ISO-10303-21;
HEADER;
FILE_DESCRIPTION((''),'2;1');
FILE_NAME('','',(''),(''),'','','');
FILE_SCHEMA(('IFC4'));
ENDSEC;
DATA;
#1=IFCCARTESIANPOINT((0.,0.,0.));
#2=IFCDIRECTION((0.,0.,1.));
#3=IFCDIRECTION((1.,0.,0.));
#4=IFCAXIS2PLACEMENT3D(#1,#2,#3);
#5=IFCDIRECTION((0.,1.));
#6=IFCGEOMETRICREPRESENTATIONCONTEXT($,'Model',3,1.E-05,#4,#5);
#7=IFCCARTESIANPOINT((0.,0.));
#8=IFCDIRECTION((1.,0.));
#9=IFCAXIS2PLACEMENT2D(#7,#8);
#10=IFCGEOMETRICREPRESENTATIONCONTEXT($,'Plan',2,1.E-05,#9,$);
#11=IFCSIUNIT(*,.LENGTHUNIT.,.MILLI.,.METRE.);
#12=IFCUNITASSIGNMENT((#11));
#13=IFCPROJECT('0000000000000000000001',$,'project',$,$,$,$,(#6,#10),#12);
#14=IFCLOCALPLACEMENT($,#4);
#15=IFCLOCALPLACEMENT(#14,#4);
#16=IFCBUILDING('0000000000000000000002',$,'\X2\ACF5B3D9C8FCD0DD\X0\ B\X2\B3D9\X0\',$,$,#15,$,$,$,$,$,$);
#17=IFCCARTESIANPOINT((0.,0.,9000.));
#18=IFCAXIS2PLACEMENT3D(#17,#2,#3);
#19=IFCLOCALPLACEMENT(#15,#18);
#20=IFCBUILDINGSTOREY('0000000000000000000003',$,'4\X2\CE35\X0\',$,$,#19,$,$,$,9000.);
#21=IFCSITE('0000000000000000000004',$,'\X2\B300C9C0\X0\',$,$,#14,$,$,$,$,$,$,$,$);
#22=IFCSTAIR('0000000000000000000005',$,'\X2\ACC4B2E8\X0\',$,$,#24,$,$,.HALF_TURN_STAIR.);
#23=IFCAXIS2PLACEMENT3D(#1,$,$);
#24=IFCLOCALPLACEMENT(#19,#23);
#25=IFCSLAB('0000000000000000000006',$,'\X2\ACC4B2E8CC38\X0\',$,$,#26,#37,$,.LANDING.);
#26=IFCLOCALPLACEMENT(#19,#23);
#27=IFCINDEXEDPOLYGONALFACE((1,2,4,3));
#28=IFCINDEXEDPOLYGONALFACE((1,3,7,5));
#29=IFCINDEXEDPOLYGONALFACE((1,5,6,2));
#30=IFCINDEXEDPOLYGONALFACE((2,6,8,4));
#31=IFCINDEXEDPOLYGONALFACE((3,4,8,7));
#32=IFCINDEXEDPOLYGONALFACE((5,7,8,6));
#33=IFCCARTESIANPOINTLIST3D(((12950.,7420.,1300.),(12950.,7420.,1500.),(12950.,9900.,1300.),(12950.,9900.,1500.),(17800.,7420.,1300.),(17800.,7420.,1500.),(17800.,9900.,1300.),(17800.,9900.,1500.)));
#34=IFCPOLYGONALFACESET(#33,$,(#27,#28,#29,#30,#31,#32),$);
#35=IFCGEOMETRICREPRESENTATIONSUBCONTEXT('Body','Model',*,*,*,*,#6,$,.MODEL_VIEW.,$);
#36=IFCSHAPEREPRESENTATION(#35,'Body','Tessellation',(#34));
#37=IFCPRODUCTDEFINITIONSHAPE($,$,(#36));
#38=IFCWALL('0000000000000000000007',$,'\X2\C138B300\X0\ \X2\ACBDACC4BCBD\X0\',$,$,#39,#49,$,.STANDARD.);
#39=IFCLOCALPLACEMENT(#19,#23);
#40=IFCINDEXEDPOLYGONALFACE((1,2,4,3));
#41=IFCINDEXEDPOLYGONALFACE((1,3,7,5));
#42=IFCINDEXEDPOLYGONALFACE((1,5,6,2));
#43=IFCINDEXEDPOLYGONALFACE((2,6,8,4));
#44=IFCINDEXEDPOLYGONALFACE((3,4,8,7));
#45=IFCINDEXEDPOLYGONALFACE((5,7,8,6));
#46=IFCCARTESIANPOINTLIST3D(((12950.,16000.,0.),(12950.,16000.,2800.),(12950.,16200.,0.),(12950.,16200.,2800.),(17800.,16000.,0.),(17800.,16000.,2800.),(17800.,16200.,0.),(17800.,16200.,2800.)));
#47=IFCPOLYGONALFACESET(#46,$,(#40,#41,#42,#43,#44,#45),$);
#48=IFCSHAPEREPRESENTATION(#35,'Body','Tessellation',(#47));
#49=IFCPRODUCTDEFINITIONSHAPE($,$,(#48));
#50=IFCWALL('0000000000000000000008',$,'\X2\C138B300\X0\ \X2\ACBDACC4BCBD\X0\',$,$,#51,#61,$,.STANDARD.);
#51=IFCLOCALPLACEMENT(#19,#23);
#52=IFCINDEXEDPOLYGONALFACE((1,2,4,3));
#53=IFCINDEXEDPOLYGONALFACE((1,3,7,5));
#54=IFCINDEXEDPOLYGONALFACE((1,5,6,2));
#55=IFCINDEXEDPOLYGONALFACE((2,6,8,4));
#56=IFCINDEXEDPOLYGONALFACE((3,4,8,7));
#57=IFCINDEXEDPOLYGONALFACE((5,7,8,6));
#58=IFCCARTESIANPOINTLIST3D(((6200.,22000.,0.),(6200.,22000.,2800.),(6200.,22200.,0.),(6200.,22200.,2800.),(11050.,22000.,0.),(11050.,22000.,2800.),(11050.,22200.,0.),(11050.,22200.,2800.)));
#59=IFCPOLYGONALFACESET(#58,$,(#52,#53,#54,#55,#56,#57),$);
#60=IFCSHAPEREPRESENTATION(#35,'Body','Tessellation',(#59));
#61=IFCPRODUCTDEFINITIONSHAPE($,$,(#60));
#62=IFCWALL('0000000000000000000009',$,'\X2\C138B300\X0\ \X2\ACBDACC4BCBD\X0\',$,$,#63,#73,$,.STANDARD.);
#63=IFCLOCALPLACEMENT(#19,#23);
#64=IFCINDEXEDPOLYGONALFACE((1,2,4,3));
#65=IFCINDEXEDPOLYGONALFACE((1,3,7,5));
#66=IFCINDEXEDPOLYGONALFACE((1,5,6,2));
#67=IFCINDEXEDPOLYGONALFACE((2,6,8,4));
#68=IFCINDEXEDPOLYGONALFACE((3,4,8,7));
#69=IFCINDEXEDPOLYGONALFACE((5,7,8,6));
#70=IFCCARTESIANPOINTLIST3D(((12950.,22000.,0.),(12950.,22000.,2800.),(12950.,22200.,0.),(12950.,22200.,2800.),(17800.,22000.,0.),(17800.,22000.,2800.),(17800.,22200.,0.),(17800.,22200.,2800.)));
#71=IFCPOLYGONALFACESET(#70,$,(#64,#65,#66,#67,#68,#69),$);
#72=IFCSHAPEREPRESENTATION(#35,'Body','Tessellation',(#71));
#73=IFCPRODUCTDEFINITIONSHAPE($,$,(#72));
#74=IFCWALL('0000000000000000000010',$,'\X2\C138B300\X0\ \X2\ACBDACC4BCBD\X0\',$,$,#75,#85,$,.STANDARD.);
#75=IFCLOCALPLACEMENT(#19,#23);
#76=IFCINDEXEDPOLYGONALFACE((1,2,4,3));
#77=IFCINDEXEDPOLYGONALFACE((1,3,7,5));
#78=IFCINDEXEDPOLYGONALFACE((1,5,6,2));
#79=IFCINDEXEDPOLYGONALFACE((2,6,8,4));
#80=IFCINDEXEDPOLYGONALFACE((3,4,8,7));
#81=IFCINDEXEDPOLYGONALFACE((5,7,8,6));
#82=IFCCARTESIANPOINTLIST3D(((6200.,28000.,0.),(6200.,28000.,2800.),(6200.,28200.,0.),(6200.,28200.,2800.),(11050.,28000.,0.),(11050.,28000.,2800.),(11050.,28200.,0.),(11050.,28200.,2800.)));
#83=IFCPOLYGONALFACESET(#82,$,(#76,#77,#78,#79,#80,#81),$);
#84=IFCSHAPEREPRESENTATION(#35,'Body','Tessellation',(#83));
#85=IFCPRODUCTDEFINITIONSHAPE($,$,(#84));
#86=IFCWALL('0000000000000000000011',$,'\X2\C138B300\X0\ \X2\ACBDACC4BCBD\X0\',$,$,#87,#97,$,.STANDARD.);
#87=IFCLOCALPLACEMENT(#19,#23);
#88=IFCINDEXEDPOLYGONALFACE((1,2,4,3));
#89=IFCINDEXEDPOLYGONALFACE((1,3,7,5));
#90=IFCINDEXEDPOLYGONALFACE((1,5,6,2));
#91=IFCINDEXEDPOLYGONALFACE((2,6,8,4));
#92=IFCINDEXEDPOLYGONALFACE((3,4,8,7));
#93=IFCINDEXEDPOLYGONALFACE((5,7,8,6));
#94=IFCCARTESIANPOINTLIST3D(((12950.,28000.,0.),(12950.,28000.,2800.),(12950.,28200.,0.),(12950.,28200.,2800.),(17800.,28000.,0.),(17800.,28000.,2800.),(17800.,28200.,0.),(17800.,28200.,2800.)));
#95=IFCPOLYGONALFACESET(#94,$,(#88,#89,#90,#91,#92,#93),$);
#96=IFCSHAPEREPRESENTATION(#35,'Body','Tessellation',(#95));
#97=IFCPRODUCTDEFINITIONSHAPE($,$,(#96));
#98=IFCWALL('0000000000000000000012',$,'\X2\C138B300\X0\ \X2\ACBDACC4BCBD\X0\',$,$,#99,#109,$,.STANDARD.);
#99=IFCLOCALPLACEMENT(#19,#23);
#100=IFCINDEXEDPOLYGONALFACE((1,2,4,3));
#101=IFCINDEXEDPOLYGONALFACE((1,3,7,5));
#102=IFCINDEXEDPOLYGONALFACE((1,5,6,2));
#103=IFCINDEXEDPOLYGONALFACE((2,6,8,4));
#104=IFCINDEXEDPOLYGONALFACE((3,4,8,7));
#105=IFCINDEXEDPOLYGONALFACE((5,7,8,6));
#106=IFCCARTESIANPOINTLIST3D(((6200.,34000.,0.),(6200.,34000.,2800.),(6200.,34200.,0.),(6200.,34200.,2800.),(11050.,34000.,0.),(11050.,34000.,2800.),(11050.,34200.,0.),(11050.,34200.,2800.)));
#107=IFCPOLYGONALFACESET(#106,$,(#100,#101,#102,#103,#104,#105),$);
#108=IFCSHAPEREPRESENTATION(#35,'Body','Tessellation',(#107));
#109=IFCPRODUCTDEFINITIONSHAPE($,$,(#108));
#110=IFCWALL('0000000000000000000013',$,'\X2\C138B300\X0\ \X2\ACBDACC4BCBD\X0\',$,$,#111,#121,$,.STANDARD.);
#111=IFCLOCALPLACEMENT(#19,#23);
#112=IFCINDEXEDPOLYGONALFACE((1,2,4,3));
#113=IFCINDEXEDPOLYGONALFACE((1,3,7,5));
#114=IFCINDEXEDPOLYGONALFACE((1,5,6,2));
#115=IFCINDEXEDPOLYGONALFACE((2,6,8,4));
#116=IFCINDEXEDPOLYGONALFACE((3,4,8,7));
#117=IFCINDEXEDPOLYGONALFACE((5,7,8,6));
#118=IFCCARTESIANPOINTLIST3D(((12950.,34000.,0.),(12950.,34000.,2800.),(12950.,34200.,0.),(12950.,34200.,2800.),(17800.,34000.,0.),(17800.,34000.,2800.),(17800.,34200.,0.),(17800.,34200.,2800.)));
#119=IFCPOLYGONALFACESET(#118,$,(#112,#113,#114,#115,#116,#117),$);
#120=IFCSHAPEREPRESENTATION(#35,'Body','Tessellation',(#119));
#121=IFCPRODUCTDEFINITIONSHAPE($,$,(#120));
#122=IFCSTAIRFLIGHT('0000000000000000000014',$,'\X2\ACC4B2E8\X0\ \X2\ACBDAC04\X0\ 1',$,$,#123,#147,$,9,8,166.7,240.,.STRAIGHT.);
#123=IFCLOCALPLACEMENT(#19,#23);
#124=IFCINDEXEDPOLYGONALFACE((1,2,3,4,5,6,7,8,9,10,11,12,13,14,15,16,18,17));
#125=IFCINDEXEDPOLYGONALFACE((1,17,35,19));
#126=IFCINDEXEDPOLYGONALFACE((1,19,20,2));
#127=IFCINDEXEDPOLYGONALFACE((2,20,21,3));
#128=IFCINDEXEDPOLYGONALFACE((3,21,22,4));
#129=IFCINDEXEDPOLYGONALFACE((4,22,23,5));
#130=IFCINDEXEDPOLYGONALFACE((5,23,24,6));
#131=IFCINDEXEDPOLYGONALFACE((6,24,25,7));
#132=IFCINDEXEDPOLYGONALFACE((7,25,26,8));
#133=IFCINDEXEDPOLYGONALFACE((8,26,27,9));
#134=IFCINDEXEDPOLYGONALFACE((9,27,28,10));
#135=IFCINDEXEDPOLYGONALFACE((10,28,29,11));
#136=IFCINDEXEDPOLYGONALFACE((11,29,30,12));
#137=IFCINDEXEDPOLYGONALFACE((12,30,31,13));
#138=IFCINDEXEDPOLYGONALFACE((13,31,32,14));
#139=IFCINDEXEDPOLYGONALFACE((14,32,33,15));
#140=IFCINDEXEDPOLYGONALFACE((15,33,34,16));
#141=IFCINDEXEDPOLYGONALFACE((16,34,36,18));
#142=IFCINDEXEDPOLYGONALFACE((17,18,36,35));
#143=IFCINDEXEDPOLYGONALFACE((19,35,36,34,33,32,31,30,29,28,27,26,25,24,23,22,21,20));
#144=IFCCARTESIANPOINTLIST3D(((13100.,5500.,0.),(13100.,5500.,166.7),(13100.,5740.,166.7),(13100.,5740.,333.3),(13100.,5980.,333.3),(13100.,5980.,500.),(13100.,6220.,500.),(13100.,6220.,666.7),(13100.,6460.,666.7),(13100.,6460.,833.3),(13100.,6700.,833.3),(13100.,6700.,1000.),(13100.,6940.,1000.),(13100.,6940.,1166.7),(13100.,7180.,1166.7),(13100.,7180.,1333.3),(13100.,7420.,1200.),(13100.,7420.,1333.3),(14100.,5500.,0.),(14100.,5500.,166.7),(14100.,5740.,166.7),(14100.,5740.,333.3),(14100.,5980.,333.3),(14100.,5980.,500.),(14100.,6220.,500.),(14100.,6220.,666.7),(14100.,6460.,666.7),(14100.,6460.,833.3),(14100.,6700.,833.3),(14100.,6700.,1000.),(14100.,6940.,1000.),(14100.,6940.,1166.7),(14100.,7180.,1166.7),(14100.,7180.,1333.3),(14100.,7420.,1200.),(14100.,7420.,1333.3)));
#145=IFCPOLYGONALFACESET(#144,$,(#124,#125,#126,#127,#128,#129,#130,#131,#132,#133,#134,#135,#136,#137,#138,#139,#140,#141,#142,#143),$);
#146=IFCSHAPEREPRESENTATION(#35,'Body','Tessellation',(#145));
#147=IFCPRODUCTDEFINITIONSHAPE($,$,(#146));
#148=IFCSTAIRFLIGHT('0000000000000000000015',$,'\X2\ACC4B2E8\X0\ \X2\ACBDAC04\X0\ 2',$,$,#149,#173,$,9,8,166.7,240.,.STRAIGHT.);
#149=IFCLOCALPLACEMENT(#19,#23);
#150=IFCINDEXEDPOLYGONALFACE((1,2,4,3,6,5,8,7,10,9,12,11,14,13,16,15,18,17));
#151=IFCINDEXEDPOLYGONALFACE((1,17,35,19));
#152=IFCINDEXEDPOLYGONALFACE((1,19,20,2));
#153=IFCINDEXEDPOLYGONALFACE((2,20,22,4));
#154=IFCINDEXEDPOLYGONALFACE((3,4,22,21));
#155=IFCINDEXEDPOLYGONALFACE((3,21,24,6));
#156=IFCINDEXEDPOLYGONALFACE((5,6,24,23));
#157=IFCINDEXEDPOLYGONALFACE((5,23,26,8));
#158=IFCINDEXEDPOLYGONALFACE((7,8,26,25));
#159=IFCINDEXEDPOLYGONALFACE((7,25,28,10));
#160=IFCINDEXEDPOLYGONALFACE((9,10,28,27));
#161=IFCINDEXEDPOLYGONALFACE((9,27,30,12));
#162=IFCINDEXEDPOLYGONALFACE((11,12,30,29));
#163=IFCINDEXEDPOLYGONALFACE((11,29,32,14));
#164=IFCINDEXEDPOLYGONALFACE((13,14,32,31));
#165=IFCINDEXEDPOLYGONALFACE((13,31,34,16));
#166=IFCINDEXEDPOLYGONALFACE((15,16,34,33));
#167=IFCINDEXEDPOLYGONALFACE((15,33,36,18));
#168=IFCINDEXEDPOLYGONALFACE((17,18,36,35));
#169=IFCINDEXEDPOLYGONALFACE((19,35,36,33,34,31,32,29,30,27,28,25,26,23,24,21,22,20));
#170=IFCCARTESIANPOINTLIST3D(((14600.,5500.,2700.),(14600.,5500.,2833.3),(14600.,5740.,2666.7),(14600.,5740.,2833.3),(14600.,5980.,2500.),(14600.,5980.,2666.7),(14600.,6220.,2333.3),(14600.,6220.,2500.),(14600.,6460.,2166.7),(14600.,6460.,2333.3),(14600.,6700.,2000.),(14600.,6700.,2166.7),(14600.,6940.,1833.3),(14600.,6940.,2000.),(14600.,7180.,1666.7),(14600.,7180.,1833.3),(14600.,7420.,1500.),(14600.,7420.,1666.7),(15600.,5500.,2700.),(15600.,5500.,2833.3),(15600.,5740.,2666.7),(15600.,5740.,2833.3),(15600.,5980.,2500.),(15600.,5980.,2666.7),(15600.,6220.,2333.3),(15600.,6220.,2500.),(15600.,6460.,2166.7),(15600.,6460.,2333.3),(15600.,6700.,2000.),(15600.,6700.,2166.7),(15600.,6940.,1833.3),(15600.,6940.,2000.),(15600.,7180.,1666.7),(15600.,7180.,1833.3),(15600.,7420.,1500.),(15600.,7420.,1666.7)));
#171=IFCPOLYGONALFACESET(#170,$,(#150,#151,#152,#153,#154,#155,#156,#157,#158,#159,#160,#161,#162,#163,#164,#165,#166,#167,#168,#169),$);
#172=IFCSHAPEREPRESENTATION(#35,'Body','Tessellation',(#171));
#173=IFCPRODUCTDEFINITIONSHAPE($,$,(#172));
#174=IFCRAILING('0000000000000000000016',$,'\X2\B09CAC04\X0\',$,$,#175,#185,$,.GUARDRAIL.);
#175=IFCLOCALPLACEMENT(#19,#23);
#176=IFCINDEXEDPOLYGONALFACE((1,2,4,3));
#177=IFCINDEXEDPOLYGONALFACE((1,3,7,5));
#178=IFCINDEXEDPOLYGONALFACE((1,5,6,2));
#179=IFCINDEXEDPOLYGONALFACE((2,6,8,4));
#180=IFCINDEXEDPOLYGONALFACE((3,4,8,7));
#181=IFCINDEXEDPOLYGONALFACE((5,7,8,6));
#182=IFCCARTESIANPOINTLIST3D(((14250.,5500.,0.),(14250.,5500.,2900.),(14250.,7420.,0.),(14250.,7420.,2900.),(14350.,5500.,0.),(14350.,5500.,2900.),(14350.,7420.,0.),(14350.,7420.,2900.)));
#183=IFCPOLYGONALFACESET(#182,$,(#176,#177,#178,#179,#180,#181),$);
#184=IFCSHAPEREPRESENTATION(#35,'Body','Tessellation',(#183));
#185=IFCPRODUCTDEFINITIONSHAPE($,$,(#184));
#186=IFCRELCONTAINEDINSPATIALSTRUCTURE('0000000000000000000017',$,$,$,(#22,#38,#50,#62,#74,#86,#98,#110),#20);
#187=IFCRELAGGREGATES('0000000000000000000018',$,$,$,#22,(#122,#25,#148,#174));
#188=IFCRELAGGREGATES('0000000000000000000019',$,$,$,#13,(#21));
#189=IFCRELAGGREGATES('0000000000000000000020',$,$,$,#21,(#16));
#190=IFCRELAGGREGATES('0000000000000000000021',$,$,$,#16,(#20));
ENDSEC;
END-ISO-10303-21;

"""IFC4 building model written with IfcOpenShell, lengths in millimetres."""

from ifc_helpers import new_model, si_unit, direction, frame, origin_with_axes, origin_2d_with_axis, place, context, subcontext, project, spatial, polyline, outline, extrude, element, aggregate, save


model = new_model("IFC4")

# Units and contexts
model_context = context("Model", 3, precision=1e-05, world=origin_with_axes(), true_north=direction((0.0, 1.0)))
plan_context = context("Plan", 2, precision=1e-05, world=origin_2d_with_axis())
body_context = subcontext(model_context, "Body", "Model", "MODEL_VIEW")
ifc_project = project(units=[si_unit("LENGTHUNIT", "METRE", prefix="MILLI")], contexts=[model_context, plan_context])

# Site, building, storey
site_placement = place(None, origin_with_axes())
site = spatial("IfcSite", under=ifc_project, at=site_placement, Name="대지")
building_placement = place(site_placement, origin_with_axes())
building = spatial("IfcBuilding", under=site, at=building_placement, Name="공동주택 B동")
storey_placement = place(building_placement, frame((0.0, 0.0, 9000.0), z_axis=(0.0, 0.0, 1.0), x_axis=(1.0, 0.0, 0.0)))
storey = spatial("IfcBuildingStorey", under=building, at=storey_placement, Name="4층", Elevation=9000.0)

# Stair, slab
stair_placement = place(storey_placement, origin_with_axes())
stair = element("IfcStair", 1, at=stair_placement, inside=storey, Name="계단", PredefinedType="HALF_TURN_STAIR")
slab_placement = place(stair_placement, origin_with_axes())
slab = element("IfcSlab", 2, at=slab_placement, Name="계단참", PredefinedType="LANDING", context=body_context, shape_type="SweptSolid", body=[
    extrude(outline(polyline([(12950.0, 7420.0), (17800.0, 7420.0), (17800.0, 9900.0), (12950.0, 9900.0), (12950.0, 7420.0)])), frame((0.0, 0.0, 1300.0), z_axis=(0.0, 0.0, 1.0), x_axis=(1.0, 0.0, 0.0)), (0.0, 0.0, 1.0), 200.0),
])

# Walls
wall_1_placement = place(storey_placement, origin_with_axes())
element("IfcWall", 3, at=wall_1_placement, inside=storey, Name="세대 경계벽", PredefinedType="STANDARD", context=body_context, shape_type="SweptSolid", body=[
    extrude(outline(polyline([(12950.0, 16200.0), (17800.0, 16200.0), (17800.0, 16000.0), (12950.0, 16000.0), (12950.0, 16200.0)])), origin_with_axes(), (0.0, 0.0, 1.0), 2800.0),
])
wall_2_placement = place(storey_placement, origin_with_axes())
element("IfcWall", 4, at=wall_2_placement, inside=storey, Name="세대 경계벽", PredefinedType="STANDARD", context=body_context, shape_type="SweptSolid", body=[
    extrude(outline(polyline([(6200.0, 22200.0), (11050.0, 22200.0), (11050.0, 22000.0), (6200.0, 22000.0), (6200.0, 22200.0)])), origin_with_axes(), (0.0, 0.0, 1.0), 2800.0),
])
wall_3_placement = place(storey_placement, origin_with_axes())
element("IfcWall", 5, at=wall_3_placement, inside=storey, Name="세대 경계벽", PredefinedType="STANDARD", context=body_context, shape_type="SweptSolid", body=[
    extrude(outline(polyline([(12950.0, 22200.0), (17800.0, 22200.0), (17800.0, 22000.0), (12950.0, 22000.0), (12950.0, 22200.0)])), origin_with_axes(), (0.0, 0.0, 1.0), 2800.0),
])
wall_4_placement = place(storey_placement, origin_with_axes())
element("IfcWall", 6, at=wall_4_placement, inside=storey, Name="세대 경계벽", PredefinedType="STANDARD", context=body_context, shape_type="SweptSolid", body=[
    extrude(outline(polyline([(6200.0, 28200.0), (11050.0, 28200.0), (11050.0, 28000.0), (6200.0, 28000.0), (6200.0, 28200.0)])), origin_with_axes(), (0.0, 0.0, 1.0), 2800.0),
])
wall_5_placement = place(storey_placement, origin_with_axes())
element("IfcWall", 7, at=wall_5_placement, inside=storey, Name="세대 경계벽", PredefinedType="STANDARD", context=body_context, shape_type="SweptSolid", body=[
    extrude(outline(polyline([(12950.0, 28200.0), (17800.0, 28200.0), (17800.0, 28000.0), (12950.0, 28000.0), (12950.0, 28200.0)])), origin_with_axes(), (0.0, 0.0, 1.0), 2800.0),
])
wall_6_placement = place(storey_placement, origin_with_axes())
element("IfcWall", 8, at=wall_6_placement, inside=storey, Name="세대 경계벽", PredefinedType="STANDARD", context=body_context, shape_type="SweptSolid", body=[
    extrude(outline(polyline([(6200.0, 34200.0), (11050.0, 34200.0), (11050.0, 34000.0), (6200.0, 34000.0), (6200.0, 34200.0)])), origin_with_axes(), (0.0, 0.0, 1.0), 2800.0),
])
wall_7_placement = place(storey_placement, origin_with_axes())
element("IfcWall", 9, at=wall_7_placement, inside=storey, Name="세대 경계벽", PredefinedType="STANDARD", context=body_context, shape_type="SweptSolid", body=[
    extrude(outline(polyline([(12950.0, 34200.0), (17800.0, 34200.0), (17800.0, 34000.0), (12950.0, 34000.0), (12950.0, 34200.0)])), origin_with_axes(), (0.0, 0.0, 1.0), 2800.0),
])

# Stair flights
stair_flight_1_placement = place(stair_placement, origin_with_axes())
stair_flight_1 = element("IfcStairFlight", 10, at=stair_flight_1_placement, Name="계단 경간 1", NumberOfRisers=9, NumberOfTreads=8, PredefinedType="STRAIGHT", RiserHeight=166.7, TreadLength=240.0, context=body_context, shape_type="SweptSolid", body=[
    extrude(outline(polyline([(0.0, 0.0), (0.0, 166.7), (240.0, 166.7), (240.0, 333.3), (480.0, 333.3), (480.0, 500.0), (720.0, 500.0), (720.0, 666.7), (960.0, 666.7), (960.0, 833.3), (1200.0, 833.3), (1200.0, 1000.0), (1440.0, 1000.0), (1440.0, 1166.7), (1680.0, 1166.7), (1680.0, 1333.3), (1920.0, 1333.3), (1920.0, 1500.0), (1920.0, 1200.0), (0.0, 0.0)])), frame((13100.0, 5500.0, 0.0), z_axis=(1.0, 0.0, 0.0), x_axis=(0.0, 1.0, 0.0)), (0.0, 0.0, 1.0), 1000.0),
])
stair_flight_2_placement = place(stair_placement, origin_with_axes())
stair_flight_2 = element("IfcStairFlight", 11, at=stair_flight_2_placement, Name="계단 경간 2", NumberOfRisers=9, NumberOfTreads=8, PredefinedType="STRAIGHT", RiserHeight=166.7, TreadLength=240.0, context=body_context, shape_type="SweptSolid", body=[
    extrude(outline(polyline([(0.0, 0.0), (0.0, 166.7), (240.0, 166.7), (240.0, 333.3), (480.0, 333.3), (480.0, 500.0), (720.0, 500.0), (720.0, 666.7), (960.0, 666.7), (960.0, 833.3), (1200.0, 833.3), (1200.0, 1000.0), (1440.0, 1000.0), (1440.0, 1166.7), (1680.0, 1166.7), (1680.0, 1333.3), (1920.0, 1333.3), (1920.0, 1500.0), (1920.0, 1200.0), (0.0, 0.0)])), frame((15600.0, 7420.0, 1500.0), z_axis=(-1.0, 0.0, 0.0), x_axis=(0.0, -1.0, 0.0)), (0.0, 0.0, 1.0), 1000.0),
])

# Railing
railing_placement = place(stair_placement, origin_with_axes())
railing = element("IfcRailing", 12, at=railing_placement, Name="난간", PredefinedType="GUARDRAIL", context=body_context, shape_type="SweptSolid", body=[
    extrude(outline(polyline([(14250.0, 5500.0), (14350.0, 5500.0), (14350.0, 7420.0), (14250.0, 7420.0), (14250.0, 5500.0)])), origin_with_axes(), (0.0, 0.0, 1.0), 2900.0),
])
aggregate(stair, [stair_flight_1, slab, stair_flight_2, railing])

save(model, "model.ifc")
